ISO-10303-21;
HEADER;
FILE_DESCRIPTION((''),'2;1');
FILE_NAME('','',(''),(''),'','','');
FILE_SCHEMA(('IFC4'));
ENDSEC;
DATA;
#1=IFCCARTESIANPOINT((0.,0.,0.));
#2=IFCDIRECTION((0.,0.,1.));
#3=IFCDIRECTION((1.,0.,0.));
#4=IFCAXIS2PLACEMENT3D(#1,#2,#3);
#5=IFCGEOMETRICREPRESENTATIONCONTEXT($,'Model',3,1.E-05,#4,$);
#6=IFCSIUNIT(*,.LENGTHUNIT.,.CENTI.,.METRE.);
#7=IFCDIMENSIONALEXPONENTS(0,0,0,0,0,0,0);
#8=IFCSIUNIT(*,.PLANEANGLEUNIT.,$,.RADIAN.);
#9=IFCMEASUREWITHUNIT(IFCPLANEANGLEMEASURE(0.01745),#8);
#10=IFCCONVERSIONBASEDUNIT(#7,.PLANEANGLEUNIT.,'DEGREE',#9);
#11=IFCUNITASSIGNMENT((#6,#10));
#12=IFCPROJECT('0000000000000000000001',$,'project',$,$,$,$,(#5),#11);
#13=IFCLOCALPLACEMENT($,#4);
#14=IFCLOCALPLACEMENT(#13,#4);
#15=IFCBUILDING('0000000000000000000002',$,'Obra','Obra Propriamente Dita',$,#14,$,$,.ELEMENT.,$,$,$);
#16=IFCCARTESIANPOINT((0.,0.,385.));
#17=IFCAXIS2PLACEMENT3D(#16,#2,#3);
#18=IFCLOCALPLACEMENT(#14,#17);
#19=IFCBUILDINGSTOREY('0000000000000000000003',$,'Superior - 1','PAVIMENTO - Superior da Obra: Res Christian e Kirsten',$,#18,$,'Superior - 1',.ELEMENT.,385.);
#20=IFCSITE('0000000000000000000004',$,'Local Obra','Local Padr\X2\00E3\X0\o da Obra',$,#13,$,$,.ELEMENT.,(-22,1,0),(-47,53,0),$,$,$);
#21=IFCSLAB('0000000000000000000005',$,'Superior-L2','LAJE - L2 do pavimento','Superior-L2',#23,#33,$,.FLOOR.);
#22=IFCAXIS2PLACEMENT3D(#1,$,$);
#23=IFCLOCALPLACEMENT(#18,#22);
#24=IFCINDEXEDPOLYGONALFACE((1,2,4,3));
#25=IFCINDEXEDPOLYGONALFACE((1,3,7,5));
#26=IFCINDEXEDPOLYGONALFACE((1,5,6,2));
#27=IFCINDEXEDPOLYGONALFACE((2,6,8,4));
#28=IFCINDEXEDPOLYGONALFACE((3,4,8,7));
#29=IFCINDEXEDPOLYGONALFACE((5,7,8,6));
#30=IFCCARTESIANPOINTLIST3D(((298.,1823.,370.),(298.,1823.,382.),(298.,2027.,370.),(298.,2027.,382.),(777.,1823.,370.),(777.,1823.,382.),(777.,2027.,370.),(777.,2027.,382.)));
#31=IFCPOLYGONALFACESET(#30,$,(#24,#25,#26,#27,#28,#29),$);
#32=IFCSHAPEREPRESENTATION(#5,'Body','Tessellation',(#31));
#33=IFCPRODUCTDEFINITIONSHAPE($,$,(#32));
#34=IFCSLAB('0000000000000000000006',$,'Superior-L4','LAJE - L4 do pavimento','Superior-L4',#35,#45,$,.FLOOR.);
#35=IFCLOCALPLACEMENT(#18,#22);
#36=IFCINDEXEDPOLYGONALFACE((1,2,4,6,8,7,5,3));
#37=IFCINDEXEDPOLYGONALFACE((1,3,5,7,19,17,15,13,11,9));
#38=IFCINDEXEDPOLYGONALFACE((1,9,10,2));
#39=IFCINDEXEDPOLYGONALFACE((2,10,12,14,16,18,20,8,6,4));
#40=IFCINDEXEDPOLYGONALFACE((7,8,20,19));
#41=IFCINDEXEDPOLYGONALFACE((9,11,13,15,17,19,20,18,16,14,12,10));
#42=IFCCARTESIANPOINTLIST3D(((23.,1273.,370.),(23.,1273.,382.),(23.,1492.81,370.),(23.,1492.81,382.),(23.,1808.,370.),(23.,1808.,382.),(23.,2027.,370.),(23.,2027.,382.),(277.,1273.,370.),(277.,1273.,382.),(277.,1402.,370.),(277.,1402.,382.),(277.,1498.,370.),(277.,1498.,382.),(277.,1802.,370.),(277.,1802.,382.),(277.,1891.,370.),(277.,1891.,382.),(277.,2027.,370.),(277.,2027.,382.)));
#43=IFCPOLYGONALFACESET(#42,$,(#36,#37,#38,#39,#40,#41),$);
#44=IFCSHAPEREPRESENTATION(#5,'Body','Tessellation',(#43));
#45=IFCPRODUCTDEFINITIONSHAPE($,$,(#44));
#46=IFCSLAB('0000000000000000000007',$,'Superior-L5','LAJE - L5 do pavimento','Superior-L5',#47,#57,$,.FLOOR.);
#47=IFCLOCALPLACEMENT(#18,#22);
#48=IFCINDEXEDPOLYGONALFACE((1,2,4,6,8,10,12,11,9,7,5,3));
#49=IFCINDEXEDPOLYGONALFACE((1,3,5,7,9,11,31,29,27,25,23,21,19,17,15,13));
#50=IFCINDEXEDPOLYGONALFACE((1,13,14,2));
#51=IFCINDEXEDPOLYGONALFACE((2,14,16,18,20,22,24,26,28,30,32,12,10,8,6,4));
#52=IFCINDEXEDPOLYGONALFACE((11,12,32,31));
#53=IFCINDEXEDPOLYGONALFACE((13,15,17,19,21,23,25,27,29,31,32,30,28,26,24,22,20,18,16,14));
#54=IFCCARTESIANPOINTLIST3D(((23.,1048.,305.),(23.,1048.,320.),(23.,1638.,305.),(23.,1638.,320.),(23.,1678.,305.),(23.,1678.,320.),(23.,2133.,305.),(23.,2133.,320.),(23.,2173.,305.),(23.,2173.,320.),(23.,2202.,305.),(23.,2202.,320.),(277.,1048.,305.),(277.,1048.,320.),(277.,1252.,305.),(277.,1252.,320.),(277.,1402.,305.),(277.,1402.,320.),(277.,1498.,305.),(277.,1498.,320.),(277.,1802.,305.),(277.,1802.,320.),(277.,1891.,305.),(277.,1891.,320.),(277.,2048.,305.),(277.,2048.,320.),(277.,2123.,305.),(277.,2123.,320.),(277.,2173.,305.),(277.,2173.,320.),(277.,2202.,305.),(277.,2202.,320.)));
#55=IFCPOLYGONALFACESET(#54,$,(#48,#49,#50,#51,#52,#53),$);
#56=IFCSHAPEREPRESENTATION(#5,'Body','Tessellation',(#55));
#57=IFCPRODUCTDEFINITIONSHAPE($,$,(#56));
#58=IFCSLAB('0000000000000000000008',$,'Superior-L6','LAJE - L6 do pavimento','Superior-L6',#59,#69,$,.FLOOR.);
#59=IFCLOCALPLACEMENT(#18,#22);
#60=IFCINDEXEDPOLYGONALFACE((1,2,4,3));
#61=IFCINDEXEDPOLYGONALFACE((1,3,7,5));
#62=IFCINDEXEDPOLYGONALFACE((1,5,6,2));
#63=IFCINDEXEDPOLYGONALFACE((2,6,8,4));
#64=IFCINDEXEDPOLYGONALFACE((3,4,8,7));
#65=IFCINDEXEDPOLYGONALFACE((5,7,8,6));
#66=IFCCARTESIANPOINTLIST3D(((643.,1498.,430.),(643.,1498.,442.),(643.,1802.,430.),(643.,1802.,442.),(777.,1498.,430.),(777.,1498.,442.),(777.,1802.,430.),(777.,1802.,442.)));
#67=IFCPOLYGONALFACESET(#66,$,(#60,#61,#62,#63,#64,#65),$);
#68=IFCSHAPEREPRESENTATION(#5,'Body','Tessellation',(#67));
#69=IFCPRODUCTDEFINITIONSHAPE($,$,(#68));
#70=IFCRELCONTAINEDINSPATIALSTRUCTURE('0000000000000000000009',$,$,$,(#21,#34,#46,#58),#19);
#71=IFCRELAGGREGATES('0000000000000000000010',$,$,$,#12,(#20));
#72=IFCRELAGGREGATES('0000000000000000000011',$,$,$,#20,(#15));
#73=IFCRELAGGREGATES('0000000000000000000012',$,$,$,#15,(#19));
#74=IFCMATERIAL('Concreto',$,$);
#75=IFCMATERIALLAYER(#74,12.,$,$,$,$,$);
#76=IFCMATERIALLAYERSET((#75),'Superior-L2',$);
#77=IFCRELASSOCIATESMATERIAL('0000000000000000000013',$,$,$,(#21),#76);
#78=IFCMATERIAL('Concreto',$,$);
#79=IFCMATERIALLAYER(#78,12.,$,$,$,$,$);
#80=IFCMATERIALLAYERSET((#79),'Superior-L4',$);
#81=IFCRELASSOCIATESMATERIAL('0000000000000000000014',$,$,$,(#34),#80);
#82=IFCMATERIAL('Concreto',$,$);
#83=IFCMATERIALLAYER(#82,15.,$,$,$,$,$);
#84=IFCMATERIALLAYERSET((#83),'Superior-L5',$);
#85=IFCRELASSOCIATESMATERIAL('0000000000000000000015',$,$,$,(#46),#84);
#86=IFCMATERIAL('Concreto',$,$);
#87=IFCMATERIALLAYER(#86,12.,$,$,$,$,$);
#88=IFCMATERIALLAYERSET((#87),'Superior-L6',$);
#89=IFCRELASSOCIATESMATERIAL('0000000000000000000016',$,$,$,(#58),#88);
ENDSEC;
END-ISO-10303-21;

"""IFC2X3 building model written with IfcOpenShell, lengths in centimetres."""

from ifc_helpers import new_model, entity, si_unit, converted_unit, frame, origin_with_axes, place, context, project, spatial, polyline, outline, extrude, material, layer, layer_set, layer_usage, element, save


model = new_model("IFC2X3")

# Units and contexts
model_context = context("Model", 3, precision=1e-05, world=origin_with_axes())
ifc_project = project(units=[si_unit("LENGTHUNIT", "METRE", prefix="CENTI"), converted_unit("PLANEANGLEUNIT", "DEGREE", entity("IfcPlaneAngleMeasure", 0.01745), si_unit("PLANEANGLEUNIT", "RADIAN"), dimensions=[0, 0, 0, 0, 0, 0, 0])], contexts=[model_context])

# Site, building, storey
site_placement = place(None, origin_with_axes())
site = spatial("IfcSite", under=ifc_project, at=site_placement, Name="Local Obra", Description="Local Padrão da Obra", CompositionType="ELEMENT", RefLatitude=(-22, 1, 0), RefLongitude=(-47, 53, 0))
building_placement = place(site_placement, origin_with_axes())
building = spatial("IfcBuilding", under=site, at=building_placement, Name="Obra", Description="Obra Propriamente Dita", CompositionType="ELEMENT")
storey_placement = place(building_placement, frame((0.0, 0.0, 385.0), z_axis=(0.0, 0.0, 1.0), x_axis=(1.0, 0.0, 0.0)))
storey = spatial("IfcBuildingStorey", under=building, at=storey_placement, Name="Superior - 1", Description="PAVIMENTO - Superior da Obra: Res Christian e Kirsten", LongName="Superior - 1", CompositionType="ELEMENT", Elevation=385.0)

# Slabs
ifc_material_1 = material(Name="Concreto")
ifc_layer_1 = layer(ifc_material_1, 12.0)
ifc_layer_set_1 = layer_set([ifc_layer_1], Name="Superior-L2")
ifc_layer_usage_1 = layer_usage(ifc_layer_set_1, "AXIS3", "POSITIVE", 0.0)
slab_1_placement = place(storey_placement, frame((777.0, 1823.0, 370.0), z_axis=(0.0, 0.0, 1.0), x_axis=(1.0, 0.0, 0.0)))
element("IfcSlab", 1, at=slab_1_placement, inside=storey, material=ifc_layer_usage_1, Name="Superior-L2", Description="LAJE - L2 do pavimento", ObjectType="Superior-L2", PredefinedType="FLOOR", context=model_context, shape_type="SweptSolid", body=[
    extrude(outline(polyline([(0.0, 204.0), (-479.0, 204.0), (-479.0, 0.0), (0.0, 0.0), (0.0, 204.0)])), origin_with_axes(), (0.0, 0.0, 1.0), 12.0),
])
ifc_material_2 = material(Name="Concreto")
ifc_layer_2 = layer(ifc_material_2, 12.0)
ifc_layer_set_2 = layer_set([ifc_layer_2], Name="Superior-L4")
ifc_layer_usage_2 = layer_usage(ifc_layer_set_2, "AXIS3", "POSITIVE", 0.0)
slab_2_placement = place(storey_placement, frame((277.0, 1891.0, 370.0), z_axis=(0.0, 0.0, 1.0), x_axis=(1.0, 0.0, 0.0)))
element("IfcSlab", 2, at=slab_2_placement, inside=storey, material=ifc_layer_usage_2, Name="Superior-L4", Description="LAJE - L4 do pavimento", ObjectType="Superior-L4", PredefinedType="FLOOR", context=model_context, shape_type="SweptSolid", body=[
    extrude(outline(polyline([(0.0, 136.0), (-254.0, 136.0), (-254.0, -83.0), (-254.0, -398.19), (-254.0, -618.0), (0.0, -618.0), (0.0, -489.0), (0.0, -393.0), (0.0, -89.0), (0.0, 0.0), (0.0, 136.0)])), origin_with_axes(), (0.0, 0.0, 1.0), 12.0),
])
ifc_material_3 = material(Name="Concreto")
ifc_layer_3 = layer(ifc_material_3, 15.0)
ifc_layer_set_3 = layer_set([ifc_layer_3], Name="Superior-L5")
ifc_layer_usage_3 = layer_usage(ifc_layer_set_3, "AXIS3", "POSITIVE", 0.0)
slab_3_placement = place(storey_placement, frame((277.0, 2173.0, 305.0), z_axis=(0.0, 0.0, 1.0), x_axis=(1.0, 0.0, 0.0)))
element("IfcSlab", 3, at=slab_3_placement, inside=storey, material=ifc_layer_usage_3, Name="Superior-L5", Description="LAJE - L5 do pavimento", ObjectType="Superior-L5", PredefinedType="FLOOR", context=model_context, shape_type="SweptSolid", body=[
    extrude(outline(polyline([(0.0, 29.0), (-254.0, 29.0), (-254.0, 0.0), (-254.0, -40.0), (-254.0, -495.0), (-254.0, -535.0), (-254.0, -1125.0), (0.0, -1125.0), (0.0, -921.0), (0.0, -771.0), (0.0, -675.0), (0.0, -371.0), (0.0, -282.0), (0.0, -125.0), (0.0, -50.0), (0.0, 0.0), (0.0, 29.0)])), origin_with_axes(), (0.0, 0.0, 1.0), 15.0),
])
ifc_material_4 = material(Name="Concreto")
ifc_layer_4 = layer(ifc_material_4, 12.0)
ifc_layer_set_4 = layer_set([ifc_layer_4], Name="Superior-L6")
ifc_layer_usage_4 = layer_usage(ifc_layer_set_4, "AXIS3", "POSITIVE", 0.0)
slab_4_placement = place(storey_placement, frame((777.0, 1498.0, 430.0), z_axis=(0.0, 0.0, 1.0), x_axis=(1.0, 0.0, 0.0)))
element("IfcSlab", 4, at=slab_4_placement, inside=storey, material=ifc_layer_usage_4, Name="Superior-L6", Description="LAJE - L6 do pavimento", ObjectType="Superior-L6", PredefinedType="FLOOR", context=model_context, shape_type="SweptSolid", body=[
    extrude(outline(polyline([(0.0, 304.0), (-134.0, 304.0), (-134.0, 0.0), (0.0, 0.0), (0.0, 304.0)])), origin_with_axes(), (0.0, 0.0, 1.0), 12.0),
])

save(model, "model.ifc")
